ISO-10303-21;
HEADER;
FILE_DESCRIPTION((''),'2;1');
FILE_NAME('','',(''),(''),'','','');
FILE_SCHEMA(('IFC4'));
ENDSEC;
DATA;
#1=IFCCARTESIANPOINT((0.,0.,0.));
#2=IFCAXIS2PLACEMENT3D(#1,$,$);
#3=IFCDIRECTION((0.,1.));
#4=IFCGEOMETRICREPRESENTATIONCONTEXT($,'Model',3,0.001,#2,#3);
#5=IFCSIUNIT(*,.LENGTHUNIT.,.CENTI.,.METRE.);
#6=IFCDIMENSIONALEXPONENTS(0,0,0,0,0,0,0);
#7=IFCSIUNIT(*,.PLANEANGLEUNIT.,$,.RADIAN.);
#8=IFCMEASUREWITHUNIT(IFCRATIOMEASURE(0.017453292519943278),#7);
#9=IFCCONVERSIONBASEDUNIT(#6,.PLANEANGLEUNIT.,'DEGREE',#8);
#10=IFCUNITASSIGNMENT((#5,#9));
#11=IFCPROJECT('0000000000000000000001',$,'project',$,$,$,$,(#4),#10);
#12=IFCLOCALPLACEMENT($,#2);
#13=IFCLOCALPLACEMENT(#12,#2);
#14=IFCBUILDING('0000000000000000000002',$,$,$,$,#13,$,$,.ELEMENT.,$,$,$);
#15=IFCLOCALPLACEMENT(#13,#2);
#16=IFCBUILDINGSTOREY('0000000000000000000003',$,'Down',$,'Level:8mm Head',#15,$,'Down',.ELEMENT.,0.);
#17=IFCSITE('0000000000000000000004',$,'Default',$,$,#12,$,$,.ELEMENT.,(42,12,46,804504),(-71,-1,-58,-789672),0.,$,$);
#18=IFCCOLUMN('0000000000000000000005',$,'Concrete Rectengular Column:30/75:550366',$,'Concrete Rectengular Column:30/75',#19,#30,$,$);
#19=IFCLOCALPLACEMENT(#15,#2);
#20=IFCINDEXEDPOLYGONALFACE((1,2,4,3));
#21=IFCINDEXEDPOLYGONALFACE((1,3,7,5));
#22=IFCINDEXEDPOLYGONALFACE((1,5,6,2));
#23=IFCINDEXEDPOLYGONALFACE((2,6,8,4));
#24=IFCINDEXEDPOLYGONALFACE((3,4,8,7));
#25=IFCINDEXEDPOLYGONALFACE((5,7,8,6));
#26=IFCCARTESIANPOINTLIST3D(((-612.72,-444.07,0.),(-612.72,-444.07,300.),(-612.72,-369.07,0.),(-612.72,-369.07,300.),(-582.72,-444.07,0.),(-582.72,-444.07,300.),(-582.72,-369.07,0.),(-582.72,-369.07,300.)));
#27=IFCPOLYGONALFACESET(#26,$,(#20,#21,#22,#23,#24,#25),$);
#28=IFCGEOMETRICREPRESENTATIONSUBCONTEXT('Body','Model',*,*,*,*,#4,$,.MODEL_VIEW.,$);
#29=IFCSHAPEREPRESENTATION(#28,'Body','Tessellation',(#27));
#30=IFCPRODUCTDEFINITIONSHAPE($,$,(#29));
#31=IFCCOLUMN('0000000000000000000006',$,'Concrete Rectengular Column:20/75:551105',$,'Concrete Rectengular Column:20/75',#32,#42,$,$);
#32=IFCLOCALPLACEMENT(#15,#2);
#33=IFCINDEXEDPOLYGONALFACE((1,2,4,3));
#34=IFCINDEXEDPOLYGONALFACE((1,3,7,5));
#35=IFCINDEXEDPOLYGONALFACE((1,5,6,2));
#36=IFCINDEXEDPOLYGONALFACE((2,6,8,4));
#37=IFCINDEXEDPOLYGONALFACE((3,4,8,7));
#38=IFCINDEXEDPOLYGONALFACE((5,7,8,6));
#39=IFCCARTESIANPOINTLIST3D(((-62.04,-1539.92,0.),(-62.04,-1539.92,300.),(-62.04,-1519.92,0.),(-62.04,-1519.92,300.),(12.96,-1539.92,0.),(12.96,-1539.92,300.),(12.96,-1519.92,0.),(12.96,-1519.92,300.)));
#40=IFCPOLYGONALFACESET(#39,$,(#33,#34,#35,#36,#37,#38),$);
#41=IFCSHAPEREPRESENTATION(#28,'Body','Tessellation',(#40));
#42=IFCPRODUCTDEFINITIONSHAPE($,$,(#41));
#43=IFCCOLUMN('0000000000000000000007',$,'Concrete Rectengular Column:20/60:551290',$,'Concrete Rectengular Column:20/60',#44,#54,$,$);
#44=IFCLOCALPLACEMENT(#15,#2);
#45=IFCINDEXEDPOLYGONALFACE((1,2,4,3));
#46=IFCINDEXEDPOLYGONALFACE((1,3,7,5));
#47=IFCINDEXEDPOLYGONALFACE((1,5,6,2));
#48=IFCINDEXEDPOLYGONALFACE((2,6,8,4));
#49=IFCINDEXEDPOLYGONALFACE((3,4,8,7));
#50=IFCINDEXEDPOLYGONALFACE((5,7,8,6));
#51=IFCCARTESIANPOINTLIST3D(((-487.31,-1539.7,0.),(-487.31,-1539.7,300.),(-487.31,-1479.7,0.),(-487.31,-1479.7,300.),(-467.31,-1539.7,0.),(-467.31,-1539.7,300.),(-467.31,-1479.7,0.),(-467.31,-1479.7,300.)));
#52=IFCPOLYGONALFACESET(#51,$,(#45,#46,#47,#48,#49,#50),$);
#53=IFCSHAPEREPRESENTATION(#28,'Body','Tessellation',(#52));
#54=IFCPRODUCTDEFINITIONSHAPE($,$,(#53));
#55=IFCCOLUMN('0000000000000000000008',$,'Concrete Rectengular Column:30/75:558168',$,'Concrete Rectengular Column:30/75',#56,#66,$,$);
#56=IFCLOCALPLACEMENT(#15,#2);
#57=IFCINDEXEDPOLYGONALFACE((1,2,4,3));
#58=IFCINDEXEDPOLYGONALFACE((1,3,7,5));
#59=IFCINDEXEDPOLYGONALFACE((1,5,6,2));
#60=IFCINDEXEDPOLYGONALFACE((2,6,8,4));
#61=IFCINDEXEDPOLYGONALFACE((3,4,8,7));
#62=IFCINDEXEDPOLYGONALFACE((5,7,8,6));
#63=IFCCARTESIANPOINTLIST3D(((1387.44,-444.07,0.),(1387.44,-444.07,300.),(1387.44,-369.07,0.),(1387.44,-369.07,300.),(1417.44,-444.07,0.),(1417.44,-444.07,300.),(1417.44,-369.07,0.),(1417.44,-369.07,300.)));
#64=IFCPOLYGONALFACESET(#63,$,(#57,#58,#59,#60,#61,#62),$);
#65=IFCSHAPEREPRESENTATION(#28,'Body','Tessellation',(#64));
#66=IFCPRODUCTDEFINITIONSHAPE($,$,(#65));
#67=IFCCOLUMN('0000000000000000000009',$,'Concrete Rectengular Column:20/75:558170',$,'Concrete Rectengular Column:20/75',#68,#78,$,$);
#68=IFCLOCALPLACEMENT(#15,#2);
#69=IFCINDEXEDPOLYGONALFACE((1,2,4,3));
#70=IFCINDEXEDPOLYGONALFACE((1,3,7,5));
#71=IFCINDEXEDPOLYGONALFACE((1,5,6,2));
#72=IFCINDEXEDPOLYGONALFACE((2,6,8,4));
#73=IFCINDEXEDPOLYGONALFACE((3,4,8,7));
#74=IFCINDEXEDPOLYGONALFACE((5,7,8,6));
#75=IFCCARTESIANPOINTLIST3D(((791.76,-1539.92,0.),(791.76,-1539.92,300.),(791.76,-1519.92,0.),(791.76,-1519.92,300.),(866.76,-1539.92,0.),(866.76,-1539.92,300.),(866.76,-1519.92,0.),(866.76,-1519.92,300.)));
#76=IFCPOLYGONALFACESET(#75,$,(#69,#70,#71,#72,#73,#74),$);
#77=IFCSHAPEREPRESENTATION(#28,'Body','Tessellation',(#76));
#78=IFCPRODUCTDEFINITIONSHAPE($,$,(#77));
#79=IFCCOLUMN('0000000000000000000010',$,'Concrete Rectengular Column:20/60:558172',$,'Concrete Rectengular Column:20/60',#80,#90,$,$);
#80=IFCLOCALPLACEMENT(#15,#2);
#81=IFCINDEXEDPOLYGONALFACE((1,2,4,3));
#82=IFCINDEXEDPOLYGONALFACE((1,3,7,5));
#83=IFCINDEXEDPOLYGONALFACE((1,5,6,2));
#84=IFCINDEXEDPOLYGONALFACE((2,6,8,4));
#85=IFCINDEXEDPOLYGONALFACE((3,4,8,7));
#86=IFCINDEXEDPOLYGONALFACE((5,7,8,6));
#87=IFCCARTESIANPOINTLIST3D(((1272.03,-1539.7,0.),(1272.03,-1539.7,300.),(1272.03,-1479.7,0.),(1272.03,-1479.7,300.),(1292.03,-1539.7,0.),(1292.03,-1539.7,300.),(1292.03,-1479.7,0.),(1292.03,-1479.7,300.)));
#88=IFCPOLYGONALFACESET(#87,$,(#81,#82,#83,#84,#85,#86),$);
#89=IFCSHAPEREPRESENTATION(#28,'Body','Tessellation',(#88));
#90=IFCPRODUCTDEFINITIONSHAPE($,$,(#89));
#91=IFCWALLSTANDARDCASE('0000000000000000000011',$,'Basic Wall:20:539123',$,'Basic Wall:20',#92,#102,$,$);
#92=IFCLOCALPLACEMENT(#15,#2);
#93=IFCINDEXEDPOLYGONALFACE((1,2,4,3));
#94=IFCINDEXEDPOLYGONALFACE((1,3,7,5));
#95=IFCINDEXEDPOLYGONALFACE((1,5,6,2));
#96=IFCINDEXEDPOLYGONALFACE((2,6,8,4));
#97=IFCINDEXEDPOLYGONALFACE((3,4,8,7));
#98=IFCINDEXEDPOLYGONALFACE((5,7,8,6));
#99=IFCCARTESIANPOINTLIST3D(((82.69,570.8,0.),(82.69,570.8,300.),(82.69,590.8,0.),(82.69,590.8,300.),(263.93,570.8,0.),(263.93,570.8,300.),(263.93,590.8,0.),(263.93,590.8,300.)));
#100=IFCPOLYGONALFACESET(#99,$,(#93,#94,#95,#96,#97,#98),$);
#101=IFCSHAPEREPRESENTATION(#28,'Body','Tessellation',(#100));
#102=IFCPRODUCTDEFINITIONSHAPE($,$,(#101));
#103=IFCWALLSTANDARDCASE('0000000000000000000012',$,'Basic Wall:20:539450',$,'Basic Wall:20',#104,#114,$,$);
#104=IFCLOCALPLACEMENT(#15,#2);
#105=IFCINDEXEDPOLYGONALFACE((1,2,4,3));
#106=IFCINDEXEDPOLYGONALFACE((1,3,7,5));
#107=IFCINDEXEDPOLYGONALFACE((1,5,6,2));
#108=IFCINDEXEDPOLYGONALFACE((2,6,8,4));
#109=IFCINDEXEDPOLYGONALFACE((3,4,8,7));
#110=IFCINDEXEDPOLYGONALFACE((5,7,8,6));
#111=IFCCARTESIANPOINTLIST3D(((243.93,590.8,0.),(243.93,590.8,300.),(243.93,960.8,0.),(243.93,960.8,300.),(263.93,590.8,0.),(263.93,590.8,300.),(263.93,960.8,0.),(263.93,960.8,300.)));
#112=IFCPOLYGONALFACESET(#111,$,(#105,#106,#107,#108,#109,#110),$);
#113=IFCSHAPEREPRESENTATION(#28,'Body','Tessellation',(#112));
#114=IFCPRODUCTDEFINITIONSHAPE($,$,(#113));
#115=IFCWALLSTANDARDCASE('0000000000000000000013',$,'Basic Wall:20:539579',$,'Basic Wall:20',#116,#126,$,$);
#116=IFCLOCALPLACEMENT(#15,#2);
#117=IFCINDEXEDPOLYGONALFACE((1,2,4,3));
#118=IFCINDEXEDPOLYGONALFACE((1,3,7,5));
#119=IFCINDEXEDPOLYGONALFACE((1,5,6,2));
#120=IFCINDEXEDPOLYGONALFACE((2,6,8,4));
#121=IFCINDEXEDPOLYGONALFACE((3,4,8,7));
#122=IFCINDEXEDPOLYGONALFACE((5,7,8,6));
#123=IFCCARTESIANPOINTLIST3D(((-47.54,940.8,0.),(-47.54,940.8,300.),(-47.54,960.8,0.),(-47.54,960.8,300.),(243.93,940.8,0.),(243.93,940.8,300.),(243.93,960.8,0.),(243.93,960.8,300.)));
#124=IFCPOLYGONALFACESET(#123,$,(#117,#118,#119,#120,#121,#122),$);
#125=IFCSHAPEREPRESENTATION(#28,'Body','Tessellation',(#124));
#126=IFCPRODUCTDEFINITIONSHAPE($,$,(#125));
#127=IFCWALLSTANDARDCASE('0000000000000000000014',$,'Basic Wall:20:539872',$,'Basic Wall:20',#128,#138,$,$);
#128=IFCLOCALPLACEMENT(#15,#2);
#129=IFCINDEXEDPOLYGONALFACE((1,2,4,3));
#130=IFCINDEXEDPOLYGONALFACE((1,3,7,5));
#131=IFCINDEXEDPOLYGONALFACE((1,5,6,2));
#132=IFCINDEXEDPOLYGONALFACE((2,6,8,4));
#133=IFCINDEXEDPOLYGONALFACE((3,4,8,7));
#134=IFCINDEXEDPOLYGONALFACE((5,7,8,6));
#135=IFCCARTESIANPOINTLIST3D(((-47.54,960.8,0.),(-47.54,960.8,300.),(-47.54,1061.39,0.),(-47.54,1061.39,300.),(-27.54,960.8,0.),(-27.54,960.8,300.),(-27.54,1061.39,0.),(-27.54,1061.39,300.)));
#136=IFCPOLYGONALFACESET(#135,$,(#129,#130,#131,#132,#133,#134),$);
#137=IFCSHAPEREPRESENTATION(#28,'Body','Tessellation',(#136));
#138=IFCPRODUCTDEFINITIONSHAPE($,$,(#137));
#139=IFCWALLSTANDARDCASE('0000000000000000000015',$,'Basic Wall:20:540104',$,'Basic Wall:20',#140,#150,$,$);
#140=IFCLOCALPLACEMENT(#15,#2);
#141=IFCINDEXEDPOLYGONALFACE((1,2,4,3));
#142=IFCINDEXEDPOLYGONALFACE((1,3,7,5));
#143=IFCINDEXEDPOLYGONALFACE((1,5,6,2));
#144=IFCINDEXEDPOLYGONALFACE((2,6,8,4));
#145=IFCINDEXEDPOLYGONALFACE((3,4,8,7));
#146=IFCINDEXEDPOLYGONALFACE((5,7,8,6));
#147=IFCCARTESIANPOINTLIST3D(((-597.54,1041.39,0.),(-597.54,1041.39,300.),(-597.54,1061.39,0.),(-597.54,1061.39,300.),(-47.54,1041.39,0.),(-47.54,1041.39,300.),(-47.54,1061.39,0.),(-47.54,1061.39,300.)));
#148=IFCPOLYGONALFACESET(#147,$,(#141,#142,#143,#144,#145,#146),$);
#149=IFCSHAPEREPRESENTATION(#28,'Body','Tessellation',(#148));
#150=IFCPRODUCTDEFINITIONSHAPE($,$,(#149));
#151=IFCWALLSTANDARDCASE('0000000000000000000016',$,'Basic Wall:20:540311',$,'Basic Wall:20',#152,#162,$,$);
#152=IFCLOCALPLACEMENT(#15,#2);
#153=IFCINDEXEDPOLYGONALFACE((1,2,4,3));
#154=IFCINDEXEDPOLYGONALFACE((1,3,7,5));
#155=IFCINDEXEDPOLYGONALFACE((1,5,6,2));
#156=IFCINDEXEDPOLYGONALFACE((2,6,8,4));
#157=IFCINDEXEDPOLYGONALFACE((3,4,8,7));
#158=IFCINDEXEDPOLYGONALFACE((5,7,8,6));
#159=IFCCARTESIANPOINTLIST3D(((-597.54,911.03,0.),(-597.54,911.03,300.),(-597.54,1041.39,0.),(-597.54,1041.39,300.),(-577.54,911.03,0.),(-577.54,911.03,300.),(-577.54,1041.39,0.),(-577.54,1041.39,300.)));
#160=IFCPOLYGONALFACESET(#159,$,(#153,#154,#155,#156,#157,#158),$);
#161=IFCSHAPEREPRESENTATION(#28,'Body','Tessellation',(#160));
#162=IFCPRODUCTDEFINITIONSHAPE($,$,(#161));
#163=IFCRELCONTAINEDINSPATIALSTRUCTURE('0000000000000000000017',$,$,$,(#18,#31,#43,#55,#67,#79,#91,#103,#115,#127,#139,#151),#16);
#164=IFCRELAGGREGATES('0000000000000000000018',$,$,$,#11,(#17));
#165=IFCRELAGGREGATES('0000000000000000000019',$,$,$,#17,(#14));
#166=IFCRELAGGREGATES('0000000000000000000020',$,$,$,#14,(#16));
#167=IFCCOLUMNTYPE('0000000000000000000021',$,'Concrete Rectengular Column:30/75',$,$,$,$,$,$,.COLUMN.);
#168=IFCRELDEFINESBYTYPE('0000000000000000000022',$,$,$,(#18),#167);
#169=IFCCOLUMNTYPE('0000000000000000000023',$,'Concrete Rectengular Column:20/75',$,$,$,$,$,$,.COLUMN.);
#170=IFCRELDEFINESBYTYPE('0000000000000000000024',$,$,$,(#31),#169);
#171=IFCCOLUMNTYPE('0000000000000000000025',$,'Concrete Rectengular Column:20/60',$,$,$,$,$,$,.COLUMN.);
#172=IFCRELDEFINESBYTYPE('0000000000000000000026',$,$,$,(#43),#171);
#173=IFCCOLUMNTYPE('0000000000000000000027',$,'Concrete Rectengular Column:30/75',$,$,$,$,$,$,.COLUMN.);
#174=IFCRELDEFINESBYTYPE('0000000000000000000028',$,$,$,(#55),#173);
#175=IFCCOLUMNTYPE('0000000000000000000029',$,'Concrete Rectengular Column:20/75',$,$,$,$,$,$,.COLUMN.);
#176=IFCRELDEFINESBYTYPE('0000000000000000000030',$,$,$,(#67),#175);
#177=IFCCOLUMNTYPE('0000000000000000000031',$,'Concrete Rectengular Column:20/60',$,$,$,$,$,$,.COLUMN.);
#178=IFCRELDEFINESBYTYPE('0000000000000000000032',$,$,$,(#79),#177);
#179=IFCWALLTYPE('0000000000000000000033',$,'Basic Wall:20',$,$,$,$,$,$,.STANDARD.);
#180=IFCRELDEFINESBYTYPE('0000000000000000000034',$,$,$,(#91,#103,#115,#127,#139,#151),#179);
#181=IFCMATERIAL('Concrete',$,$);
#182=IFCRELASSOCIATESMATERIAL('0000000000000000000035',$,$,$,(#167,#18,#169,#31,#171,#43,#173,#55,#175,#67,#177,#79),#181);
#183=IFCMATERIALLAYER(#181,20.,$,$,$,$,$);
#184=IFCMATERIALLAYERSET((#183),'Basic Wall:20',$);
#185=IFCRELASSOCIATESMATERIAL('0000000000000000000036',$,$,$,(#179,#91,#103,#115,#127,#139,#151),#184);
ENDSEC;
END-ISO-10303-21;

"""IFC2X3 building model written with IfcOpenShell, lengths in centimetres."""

from ifc_helpers import new_model, entity, si_unit, converted_unit, direction, frame, frame_2d, origin, place, context, subcontext, project, spatial, rectangle, extrude, source, transform, mapped, material, layer, layer_set, layer_usage, type_object, type_shapes, element, save


model = new_model("IFC2X3")

# Units and contexts
model_context = context("Model", 3, precision=0.001, world=origin(), true_north=direction((0.0, 1.0)))
body_context = subcontext(model_context, "Body", "Model", "MODEL_VIEW")
ifc_project = project(units=[si_unit("LENGTHUNIT", "METRE", prefix="CENTI"), converted_unit("PLANEANGLEUNIT", "DEGREE", entity("IfcRatioMeasure", 0.017453292519943278), si_unit("PLANEANGLEUNIT", "RADIAN"), dimensions=[0, 0, 0, 0, 0, 0, 0])], contexts=[model_context])

# Site, building, storey
site_placement = place(None, origin())
site = spatial("IfcSite", under=ifc_project, at=site_placement, Name="Default", CompositionType="ELEMENT", RefLatitude=(42, 12, 46, 804504), RefLongitude=(-71, -1, -58, -789672), RefElevation=0.0)
building_placement = place(site_placement, origin())
building = spatial("IfcBuilding", under=site, at=building_placement, CompositionType="ELEMENT")
storey_placement = place(building_placement, origin())
storey = spatial("IfcBuildingStorey", under=building, at=storey_placement, Name="Down", ObjectType="Level:8mm Head", LongName="Down", CompositionType="ELEMENT", Elevation=0.0)

# Columns
ifc_material = material(Name="Concrete")
column_type_1 = type_object("IfcColumnType", Name="Concrete Rectengular Column:30/75", PredefinedType="COLUMN", material=ifc_material)
shared_shape_1 = source(origin(), body_context, "Body", "SweptSolid", [
    extrude(rectangle(XDim=75.0, YDim=30.0, at=frame_2d((0.0, 0.0), x_axis=(1.0, 0.0))), frame((-597.72, -406.57, 0.0), z_axis=(0.0, 0.0, 1.0), x_axis=(0.0, -1.0, 0.0)), (0.0, 0.0, 1.0), 300.0),
])
type_shapes(column_type_1, [shared_shape_1])
column_1_placement = place(storey_placement, origin())
element("IfcColumn", 1, at=column_1_placement, inside=storey, type_object=column_type_1, material=ifc_material, Name="Concrete Rectengular Column:30/75:550366", ObjectType="Concrete Rectengular Column:30/75", context=body_context, shape_type="MappedRepresentation", body=[
    mapped(shared_shape_1, transform((0.0, 0.0, 0.0), scale=1.0)),
])
column_type_2 = type_object("IfcColumnType", Name="Concrete Rectengular Column:20/75", PredefinedType="COLUMN", material=ifc_material)
shared_shape_2 = source(origin(), body_context, "Body", "SweptSolid", [
    extrude(rectangle(XDim=20.0, YDim=75.0, at=frame_2d((0.0, 0.0), x_axis=(1.0, 0.0))), frame((-24.54, -1529.92, 0.0), z_axis=(0.0, 0.0, 1.0), x_axis=(0.0, -1.0, 0.0)), (0.0, 0.0, 1.0), 300.0),
])
type_shapes(column_type_2, [shared_shape_2])
column_2_placement = place(storey_placement, origin())
element("IfcColumn", 2, at=column_2_placement, inside=storey, type_object=column_type_2, material=ifc_material, Name="Concrete Rectengular Column:20/75:551105", ObjectType="Concrete Rectengular Column:20/75", context=body_context, shape_type="MappedRepresentation", body=[
    mapped(shared_shape_2, transform((0.0, 0.0, 0.0), scale=1.0)),
])
column_type_3 = type_object("IfcColumnType", Name="Concrete Rectengular Column:20/60", PredefinedType="COLUMN", material=ifc_material)
shared_shape_3 = source(origin(), body_context, "Body", "SweptSolid", [
    extrude(rectangle(XDim=60.0, YDim=20.0, at=frame_2d((0.0, 0.0), x_axis=(1.0, 0.0))), frame((-477.31, -1509.7, 0.0), z_axis=(0.0, 0.0, 1.0), x_axis=(0.0, -1.0, 0.0)), (0.0, 0.0, 1.0), 300.0),
])
type_shapes(column_type_3, [shared_shape_3])
column_3_placement = place(storey_placement, origin())
element("IfcColumn", 3, at=column_3_placement, inside=storey, type_object=column_type_3, material=ifc_material, Name="Concrete Rectengular Column:20/60:551290", ObjectType="Concrete Rectengular Column:20/60", context=body_context, shape_type="MappedRepresentation", body=[
    mapped(shared_shape_3, transform((0.0, 0.0, 0.0), scale=1.0)),
])
column_type_4 = type_object("IfcColumnType", Name="Concrete Rectengular Column:30/75", PredefinedType="COLUMN", material=ifc_material)
shared_shape_4 = source(origin(), body_context, "Body", "SweptSolid", [
    extrude(rectangle(XDim=75.0, YDim=30.0, at=frame_2d((0.0, 0.0), x_axis=(1.0, 0.0))), frame((1402.44, -406.57, 0.0), z_axis=(0.0, 0.0, 1.0), x_axis=(0.0, -1.0, 0.0)), (0.0, 0.0, 1.0), 300.0),
])
type_shapes(column_type_4, [shared_shape_4])
column_4_placement = place(storey_placement, origin())
element("IfcColumn", 4, at=column_4_placement, inside=storey, type_object=column_type_4, material=ifc_material, Name="Concrete Rectengular Column:30/75:558168", ObjectType="Concrete Rectengular Column:30/75", context=body_context, shape_type="MappedRepresentation", body=[
    mapped(shared_shape_4, transform((0.0, 0.0, 0.0), scale=1.0)),
])
column_type_5 = type_object("IfcColumnType", Name="Concrete Rectengular Column:20/75", PredefinedType="COLUMN", material=ifc_material)
shared_shape_5 = source(origin(), body_context, "Body", "SweptSolid", [
    extrude(rectangle(XDim=20.0, YDim=75.0, at=frame_2d((0.0, 0.0), x_axis=(1.0, 0.0))), frame((829.26, -1529.92, 0.0), z_axis=(0.0, 0.0, 1.0), x_axis=(0.0, -1.0, 0.0)), (0.0, 0.0, 1.0), 300.0),
])
type_shapes(column_type_5, [shared_shape_5])
column_5_placement = place(storey_placement, origin())
element("IfcColumn", 5, at=column_5_placement, inside=storey, type_object=column_type_5, material=ifc_material, Name="Concrete Rectengular Column:20/75:558170", ObjectType="Concrete Rectengular Column:20/75", context=body_context, shape_type="MappedRepresentation", body=[
    mapped(shared_shape_5, transform((0.0, 0.0, 0.0), scale=1.0)),
])
column_type_6 = type_object("IfcColumnType", Name="Concrete Rectengular Column:20/60", PredefinedType="COLUMN", material=ifc_material)
shared_shape_6 = source(origin(), body_context, "Body", "SweptSolid", [
    extrude(rectangle(XDim=60.0, YDim=20.0, at=frame_2d((0.0, 0.0), x_axis=(1.0, 0.0))), frame((1282.03, -1509.7, 0.0), z_axis=(0.0, 0.0, 1.0), x_axis=(0.0, -1.0, 0.0)), (0.0, 0.0, 1.0), 300.0),
])
type_shapes(column_type_6, [shared_shape_6])
column_6_placement = place(storey_placement, origin())
element("IfcColumn", 6, at=column_6_placement, inside=storey, type_object=column_type_6, material=ifc_material, Name="Concrete Rectengular Column:20/60:558172", ObjectType="Concrete Rectengular Column:20/60", context=body_context, shape_type="MappedRepresentation", body=[
    mapped(shared_shape_6, transform((0.0, 0.0, 0.0), scale=1.0)),
])

# Walls
ifc_layer_1 = layer(ifc_material, 20.0)
ifc_layer_set_1 = layer_set([ifc_layer_1], Name="Basic Wall:20")
ifc_layer_usage_1 = layer_usage(ifc_layer_set_1, "AXIS2", "NEGATIVE", 10.0)
wall_type_1 = type_object("IfcWallType", Name="Basic Wall:20", PredefinedType="STANDARD", material=ifc_layer_set_1)
wall_1_placement = place(storey_placement, frame((82.69, 580.8, 0.0)))
element("IfcWallStandardCase", 7, at=wall_1_placement, inside=storey, type_object=wall_type_1, material=ifc_layer_usage_1, Name="Basic Wall:20:539123", ObjectType="Basic Wall:20", context=body_context, shape_type="SweptSolid", body=[
    extrude(rectangle(XDim=181.24, YDim=20.0, at=frame_2d((90.62, 0.0), x_axis=(-1.0, 0.0))), origin(), (0.0, 0.0, 1.0), 300.0),
])
ifc_layer_usage_2 = layer_usage(ifc_layer_set_1, "AXIS2", "POSITIVE", -10.0)
wall_2_placement = place(storey_placement, frame((253.93, 590.8, 0.0), z_axis=(0.0, 0.0, 1.0), x_axis=(0.0, 1.0, 0.0)))
element("IfcWallStandardCase", 8, at=wall_2_placement, inside=storey, type_object=wall_type_1, material=ifc_layer_usage_2, Name="Basic Wall:20:539450", ObjectType="Basic Wall:20", context=body_context, shape_type="SweptSolid", body=[
    extrude(rectangle(XDim=370.0, YDim=20.0, at=frame_2d((185.0, 0.0), x_axis=(-1.0, 0.0))), origin(), (0.0, 0.0, 1.0), 300.0),
])
ifc_layer_usage_3 = layer_usage(ifc_layer_set_1, "AXIS2", "POSITIVE", -10.0)
wall_3_placement = place(storey_placement, frame((243.93, 950.8, 0.0), z_axis=(0.0, 0.0, 1.0), x_axis=(-1.0, 0.0, 0.0)))
element("IfcWallStandardCase", 9, at=wall_3_placement, inside=storey, type_object=wall_type_1, material=ifc_layer_usage_3, Name="Basic Wall:20:539579", ObjectType="Basic Wall:20", context=body_context, shape_type="SweptSolid", body=[
    extrude(rectangle(XDim=291.47, YDim=20.0, at=frame_2d((145.73, 0.0), x_axis=(-1.0, 0.0))), origin(), (0.0, 0.0, 1.0), 300.0),
])
ifc_layer_usage_4 = layer_usage(ifc_layer_set_1, "AXIS2", "NEGATIVE", 10.0)
wall_4_placement = place(storey_placement, frame((-37.54, 960.8, 0.0), z_axis=(0.0, 0.0, 1.0), x_axis=(0.0, 1.0, 0.0)))
element("IfcWallStandardCase", 10, at=wall_4_placement, inside=storey, type_object=wall_type_1, material=ifc_layer_usage_4, Name="Basic Wall:20:539872", ObjectType="Basic Wall:20", context=body_context, shape_type="SweptSolid", body=[
    extrude(rectangle(XDim=100.6, YDim=20.0, at=frame_2d((50.3, 0.0), x_axis=(-1.0, 0.0))), origin(), (0.0, 0.0, 1.0), 300.0),
])
ifc_layer_usage_5 = layer_usage(ifc_layer_set_1, "AXIS2", "POSITIVE", -10.0)
wall_5_placement = place(storey_placement, frame((-47.54, 1051.39, 0.0), z_axis=(0.0, 0.0, 1.0), x_axis=(-1.0, 0.0, 0.0)))
element("IfcWallStandardCase", 11, at=wall_5_placement, inside=storey, type_object=wall_type_1, material=ifc_layer_usage_5, Name="Basic Wall:20:540104", ObjectType="Basic Wall:20", context=body_context, shape_type="SweptSolid", body=[
    extrude(rectangle(XDim=550.0, YDim=20.0, at=frame_2d((275.0, 0.0), x_axis=(-1.0, 0.0))), origin(), (0.0, 0.0, 1.0), 300.0),
])
ifc_layer_usage_6 = layer_usage(ifc_layer_set_1, "AXIS2", "POSITIVE", -10.0)
wall_6_placement = place(storey_placement, frame((-587.54, 1041.39, 0.0), z_axis=(0.0, 0.0, 1.0), x_axis=(0.0, -1.0, 0.0)))
element("IfcWallStandardCase", 12, at=wall_6_placement, inside=storey, type_object=wall_type_1, material=ifc_layer_usage_6, Name="Basic Wall:20:540311", ObjectType="Basic Wall:20", context=body_context, shape_type="SweptSolid", body=[
    extrude(rectangle(XDim=130.36, YDim=20.0, at=frame_2d((65.18, 0.0), x_axis=(-1.0, 0.0))), origin(), (0.0, 0.0, 1.0), 300.0),
])

save(model, "model.ifc")
